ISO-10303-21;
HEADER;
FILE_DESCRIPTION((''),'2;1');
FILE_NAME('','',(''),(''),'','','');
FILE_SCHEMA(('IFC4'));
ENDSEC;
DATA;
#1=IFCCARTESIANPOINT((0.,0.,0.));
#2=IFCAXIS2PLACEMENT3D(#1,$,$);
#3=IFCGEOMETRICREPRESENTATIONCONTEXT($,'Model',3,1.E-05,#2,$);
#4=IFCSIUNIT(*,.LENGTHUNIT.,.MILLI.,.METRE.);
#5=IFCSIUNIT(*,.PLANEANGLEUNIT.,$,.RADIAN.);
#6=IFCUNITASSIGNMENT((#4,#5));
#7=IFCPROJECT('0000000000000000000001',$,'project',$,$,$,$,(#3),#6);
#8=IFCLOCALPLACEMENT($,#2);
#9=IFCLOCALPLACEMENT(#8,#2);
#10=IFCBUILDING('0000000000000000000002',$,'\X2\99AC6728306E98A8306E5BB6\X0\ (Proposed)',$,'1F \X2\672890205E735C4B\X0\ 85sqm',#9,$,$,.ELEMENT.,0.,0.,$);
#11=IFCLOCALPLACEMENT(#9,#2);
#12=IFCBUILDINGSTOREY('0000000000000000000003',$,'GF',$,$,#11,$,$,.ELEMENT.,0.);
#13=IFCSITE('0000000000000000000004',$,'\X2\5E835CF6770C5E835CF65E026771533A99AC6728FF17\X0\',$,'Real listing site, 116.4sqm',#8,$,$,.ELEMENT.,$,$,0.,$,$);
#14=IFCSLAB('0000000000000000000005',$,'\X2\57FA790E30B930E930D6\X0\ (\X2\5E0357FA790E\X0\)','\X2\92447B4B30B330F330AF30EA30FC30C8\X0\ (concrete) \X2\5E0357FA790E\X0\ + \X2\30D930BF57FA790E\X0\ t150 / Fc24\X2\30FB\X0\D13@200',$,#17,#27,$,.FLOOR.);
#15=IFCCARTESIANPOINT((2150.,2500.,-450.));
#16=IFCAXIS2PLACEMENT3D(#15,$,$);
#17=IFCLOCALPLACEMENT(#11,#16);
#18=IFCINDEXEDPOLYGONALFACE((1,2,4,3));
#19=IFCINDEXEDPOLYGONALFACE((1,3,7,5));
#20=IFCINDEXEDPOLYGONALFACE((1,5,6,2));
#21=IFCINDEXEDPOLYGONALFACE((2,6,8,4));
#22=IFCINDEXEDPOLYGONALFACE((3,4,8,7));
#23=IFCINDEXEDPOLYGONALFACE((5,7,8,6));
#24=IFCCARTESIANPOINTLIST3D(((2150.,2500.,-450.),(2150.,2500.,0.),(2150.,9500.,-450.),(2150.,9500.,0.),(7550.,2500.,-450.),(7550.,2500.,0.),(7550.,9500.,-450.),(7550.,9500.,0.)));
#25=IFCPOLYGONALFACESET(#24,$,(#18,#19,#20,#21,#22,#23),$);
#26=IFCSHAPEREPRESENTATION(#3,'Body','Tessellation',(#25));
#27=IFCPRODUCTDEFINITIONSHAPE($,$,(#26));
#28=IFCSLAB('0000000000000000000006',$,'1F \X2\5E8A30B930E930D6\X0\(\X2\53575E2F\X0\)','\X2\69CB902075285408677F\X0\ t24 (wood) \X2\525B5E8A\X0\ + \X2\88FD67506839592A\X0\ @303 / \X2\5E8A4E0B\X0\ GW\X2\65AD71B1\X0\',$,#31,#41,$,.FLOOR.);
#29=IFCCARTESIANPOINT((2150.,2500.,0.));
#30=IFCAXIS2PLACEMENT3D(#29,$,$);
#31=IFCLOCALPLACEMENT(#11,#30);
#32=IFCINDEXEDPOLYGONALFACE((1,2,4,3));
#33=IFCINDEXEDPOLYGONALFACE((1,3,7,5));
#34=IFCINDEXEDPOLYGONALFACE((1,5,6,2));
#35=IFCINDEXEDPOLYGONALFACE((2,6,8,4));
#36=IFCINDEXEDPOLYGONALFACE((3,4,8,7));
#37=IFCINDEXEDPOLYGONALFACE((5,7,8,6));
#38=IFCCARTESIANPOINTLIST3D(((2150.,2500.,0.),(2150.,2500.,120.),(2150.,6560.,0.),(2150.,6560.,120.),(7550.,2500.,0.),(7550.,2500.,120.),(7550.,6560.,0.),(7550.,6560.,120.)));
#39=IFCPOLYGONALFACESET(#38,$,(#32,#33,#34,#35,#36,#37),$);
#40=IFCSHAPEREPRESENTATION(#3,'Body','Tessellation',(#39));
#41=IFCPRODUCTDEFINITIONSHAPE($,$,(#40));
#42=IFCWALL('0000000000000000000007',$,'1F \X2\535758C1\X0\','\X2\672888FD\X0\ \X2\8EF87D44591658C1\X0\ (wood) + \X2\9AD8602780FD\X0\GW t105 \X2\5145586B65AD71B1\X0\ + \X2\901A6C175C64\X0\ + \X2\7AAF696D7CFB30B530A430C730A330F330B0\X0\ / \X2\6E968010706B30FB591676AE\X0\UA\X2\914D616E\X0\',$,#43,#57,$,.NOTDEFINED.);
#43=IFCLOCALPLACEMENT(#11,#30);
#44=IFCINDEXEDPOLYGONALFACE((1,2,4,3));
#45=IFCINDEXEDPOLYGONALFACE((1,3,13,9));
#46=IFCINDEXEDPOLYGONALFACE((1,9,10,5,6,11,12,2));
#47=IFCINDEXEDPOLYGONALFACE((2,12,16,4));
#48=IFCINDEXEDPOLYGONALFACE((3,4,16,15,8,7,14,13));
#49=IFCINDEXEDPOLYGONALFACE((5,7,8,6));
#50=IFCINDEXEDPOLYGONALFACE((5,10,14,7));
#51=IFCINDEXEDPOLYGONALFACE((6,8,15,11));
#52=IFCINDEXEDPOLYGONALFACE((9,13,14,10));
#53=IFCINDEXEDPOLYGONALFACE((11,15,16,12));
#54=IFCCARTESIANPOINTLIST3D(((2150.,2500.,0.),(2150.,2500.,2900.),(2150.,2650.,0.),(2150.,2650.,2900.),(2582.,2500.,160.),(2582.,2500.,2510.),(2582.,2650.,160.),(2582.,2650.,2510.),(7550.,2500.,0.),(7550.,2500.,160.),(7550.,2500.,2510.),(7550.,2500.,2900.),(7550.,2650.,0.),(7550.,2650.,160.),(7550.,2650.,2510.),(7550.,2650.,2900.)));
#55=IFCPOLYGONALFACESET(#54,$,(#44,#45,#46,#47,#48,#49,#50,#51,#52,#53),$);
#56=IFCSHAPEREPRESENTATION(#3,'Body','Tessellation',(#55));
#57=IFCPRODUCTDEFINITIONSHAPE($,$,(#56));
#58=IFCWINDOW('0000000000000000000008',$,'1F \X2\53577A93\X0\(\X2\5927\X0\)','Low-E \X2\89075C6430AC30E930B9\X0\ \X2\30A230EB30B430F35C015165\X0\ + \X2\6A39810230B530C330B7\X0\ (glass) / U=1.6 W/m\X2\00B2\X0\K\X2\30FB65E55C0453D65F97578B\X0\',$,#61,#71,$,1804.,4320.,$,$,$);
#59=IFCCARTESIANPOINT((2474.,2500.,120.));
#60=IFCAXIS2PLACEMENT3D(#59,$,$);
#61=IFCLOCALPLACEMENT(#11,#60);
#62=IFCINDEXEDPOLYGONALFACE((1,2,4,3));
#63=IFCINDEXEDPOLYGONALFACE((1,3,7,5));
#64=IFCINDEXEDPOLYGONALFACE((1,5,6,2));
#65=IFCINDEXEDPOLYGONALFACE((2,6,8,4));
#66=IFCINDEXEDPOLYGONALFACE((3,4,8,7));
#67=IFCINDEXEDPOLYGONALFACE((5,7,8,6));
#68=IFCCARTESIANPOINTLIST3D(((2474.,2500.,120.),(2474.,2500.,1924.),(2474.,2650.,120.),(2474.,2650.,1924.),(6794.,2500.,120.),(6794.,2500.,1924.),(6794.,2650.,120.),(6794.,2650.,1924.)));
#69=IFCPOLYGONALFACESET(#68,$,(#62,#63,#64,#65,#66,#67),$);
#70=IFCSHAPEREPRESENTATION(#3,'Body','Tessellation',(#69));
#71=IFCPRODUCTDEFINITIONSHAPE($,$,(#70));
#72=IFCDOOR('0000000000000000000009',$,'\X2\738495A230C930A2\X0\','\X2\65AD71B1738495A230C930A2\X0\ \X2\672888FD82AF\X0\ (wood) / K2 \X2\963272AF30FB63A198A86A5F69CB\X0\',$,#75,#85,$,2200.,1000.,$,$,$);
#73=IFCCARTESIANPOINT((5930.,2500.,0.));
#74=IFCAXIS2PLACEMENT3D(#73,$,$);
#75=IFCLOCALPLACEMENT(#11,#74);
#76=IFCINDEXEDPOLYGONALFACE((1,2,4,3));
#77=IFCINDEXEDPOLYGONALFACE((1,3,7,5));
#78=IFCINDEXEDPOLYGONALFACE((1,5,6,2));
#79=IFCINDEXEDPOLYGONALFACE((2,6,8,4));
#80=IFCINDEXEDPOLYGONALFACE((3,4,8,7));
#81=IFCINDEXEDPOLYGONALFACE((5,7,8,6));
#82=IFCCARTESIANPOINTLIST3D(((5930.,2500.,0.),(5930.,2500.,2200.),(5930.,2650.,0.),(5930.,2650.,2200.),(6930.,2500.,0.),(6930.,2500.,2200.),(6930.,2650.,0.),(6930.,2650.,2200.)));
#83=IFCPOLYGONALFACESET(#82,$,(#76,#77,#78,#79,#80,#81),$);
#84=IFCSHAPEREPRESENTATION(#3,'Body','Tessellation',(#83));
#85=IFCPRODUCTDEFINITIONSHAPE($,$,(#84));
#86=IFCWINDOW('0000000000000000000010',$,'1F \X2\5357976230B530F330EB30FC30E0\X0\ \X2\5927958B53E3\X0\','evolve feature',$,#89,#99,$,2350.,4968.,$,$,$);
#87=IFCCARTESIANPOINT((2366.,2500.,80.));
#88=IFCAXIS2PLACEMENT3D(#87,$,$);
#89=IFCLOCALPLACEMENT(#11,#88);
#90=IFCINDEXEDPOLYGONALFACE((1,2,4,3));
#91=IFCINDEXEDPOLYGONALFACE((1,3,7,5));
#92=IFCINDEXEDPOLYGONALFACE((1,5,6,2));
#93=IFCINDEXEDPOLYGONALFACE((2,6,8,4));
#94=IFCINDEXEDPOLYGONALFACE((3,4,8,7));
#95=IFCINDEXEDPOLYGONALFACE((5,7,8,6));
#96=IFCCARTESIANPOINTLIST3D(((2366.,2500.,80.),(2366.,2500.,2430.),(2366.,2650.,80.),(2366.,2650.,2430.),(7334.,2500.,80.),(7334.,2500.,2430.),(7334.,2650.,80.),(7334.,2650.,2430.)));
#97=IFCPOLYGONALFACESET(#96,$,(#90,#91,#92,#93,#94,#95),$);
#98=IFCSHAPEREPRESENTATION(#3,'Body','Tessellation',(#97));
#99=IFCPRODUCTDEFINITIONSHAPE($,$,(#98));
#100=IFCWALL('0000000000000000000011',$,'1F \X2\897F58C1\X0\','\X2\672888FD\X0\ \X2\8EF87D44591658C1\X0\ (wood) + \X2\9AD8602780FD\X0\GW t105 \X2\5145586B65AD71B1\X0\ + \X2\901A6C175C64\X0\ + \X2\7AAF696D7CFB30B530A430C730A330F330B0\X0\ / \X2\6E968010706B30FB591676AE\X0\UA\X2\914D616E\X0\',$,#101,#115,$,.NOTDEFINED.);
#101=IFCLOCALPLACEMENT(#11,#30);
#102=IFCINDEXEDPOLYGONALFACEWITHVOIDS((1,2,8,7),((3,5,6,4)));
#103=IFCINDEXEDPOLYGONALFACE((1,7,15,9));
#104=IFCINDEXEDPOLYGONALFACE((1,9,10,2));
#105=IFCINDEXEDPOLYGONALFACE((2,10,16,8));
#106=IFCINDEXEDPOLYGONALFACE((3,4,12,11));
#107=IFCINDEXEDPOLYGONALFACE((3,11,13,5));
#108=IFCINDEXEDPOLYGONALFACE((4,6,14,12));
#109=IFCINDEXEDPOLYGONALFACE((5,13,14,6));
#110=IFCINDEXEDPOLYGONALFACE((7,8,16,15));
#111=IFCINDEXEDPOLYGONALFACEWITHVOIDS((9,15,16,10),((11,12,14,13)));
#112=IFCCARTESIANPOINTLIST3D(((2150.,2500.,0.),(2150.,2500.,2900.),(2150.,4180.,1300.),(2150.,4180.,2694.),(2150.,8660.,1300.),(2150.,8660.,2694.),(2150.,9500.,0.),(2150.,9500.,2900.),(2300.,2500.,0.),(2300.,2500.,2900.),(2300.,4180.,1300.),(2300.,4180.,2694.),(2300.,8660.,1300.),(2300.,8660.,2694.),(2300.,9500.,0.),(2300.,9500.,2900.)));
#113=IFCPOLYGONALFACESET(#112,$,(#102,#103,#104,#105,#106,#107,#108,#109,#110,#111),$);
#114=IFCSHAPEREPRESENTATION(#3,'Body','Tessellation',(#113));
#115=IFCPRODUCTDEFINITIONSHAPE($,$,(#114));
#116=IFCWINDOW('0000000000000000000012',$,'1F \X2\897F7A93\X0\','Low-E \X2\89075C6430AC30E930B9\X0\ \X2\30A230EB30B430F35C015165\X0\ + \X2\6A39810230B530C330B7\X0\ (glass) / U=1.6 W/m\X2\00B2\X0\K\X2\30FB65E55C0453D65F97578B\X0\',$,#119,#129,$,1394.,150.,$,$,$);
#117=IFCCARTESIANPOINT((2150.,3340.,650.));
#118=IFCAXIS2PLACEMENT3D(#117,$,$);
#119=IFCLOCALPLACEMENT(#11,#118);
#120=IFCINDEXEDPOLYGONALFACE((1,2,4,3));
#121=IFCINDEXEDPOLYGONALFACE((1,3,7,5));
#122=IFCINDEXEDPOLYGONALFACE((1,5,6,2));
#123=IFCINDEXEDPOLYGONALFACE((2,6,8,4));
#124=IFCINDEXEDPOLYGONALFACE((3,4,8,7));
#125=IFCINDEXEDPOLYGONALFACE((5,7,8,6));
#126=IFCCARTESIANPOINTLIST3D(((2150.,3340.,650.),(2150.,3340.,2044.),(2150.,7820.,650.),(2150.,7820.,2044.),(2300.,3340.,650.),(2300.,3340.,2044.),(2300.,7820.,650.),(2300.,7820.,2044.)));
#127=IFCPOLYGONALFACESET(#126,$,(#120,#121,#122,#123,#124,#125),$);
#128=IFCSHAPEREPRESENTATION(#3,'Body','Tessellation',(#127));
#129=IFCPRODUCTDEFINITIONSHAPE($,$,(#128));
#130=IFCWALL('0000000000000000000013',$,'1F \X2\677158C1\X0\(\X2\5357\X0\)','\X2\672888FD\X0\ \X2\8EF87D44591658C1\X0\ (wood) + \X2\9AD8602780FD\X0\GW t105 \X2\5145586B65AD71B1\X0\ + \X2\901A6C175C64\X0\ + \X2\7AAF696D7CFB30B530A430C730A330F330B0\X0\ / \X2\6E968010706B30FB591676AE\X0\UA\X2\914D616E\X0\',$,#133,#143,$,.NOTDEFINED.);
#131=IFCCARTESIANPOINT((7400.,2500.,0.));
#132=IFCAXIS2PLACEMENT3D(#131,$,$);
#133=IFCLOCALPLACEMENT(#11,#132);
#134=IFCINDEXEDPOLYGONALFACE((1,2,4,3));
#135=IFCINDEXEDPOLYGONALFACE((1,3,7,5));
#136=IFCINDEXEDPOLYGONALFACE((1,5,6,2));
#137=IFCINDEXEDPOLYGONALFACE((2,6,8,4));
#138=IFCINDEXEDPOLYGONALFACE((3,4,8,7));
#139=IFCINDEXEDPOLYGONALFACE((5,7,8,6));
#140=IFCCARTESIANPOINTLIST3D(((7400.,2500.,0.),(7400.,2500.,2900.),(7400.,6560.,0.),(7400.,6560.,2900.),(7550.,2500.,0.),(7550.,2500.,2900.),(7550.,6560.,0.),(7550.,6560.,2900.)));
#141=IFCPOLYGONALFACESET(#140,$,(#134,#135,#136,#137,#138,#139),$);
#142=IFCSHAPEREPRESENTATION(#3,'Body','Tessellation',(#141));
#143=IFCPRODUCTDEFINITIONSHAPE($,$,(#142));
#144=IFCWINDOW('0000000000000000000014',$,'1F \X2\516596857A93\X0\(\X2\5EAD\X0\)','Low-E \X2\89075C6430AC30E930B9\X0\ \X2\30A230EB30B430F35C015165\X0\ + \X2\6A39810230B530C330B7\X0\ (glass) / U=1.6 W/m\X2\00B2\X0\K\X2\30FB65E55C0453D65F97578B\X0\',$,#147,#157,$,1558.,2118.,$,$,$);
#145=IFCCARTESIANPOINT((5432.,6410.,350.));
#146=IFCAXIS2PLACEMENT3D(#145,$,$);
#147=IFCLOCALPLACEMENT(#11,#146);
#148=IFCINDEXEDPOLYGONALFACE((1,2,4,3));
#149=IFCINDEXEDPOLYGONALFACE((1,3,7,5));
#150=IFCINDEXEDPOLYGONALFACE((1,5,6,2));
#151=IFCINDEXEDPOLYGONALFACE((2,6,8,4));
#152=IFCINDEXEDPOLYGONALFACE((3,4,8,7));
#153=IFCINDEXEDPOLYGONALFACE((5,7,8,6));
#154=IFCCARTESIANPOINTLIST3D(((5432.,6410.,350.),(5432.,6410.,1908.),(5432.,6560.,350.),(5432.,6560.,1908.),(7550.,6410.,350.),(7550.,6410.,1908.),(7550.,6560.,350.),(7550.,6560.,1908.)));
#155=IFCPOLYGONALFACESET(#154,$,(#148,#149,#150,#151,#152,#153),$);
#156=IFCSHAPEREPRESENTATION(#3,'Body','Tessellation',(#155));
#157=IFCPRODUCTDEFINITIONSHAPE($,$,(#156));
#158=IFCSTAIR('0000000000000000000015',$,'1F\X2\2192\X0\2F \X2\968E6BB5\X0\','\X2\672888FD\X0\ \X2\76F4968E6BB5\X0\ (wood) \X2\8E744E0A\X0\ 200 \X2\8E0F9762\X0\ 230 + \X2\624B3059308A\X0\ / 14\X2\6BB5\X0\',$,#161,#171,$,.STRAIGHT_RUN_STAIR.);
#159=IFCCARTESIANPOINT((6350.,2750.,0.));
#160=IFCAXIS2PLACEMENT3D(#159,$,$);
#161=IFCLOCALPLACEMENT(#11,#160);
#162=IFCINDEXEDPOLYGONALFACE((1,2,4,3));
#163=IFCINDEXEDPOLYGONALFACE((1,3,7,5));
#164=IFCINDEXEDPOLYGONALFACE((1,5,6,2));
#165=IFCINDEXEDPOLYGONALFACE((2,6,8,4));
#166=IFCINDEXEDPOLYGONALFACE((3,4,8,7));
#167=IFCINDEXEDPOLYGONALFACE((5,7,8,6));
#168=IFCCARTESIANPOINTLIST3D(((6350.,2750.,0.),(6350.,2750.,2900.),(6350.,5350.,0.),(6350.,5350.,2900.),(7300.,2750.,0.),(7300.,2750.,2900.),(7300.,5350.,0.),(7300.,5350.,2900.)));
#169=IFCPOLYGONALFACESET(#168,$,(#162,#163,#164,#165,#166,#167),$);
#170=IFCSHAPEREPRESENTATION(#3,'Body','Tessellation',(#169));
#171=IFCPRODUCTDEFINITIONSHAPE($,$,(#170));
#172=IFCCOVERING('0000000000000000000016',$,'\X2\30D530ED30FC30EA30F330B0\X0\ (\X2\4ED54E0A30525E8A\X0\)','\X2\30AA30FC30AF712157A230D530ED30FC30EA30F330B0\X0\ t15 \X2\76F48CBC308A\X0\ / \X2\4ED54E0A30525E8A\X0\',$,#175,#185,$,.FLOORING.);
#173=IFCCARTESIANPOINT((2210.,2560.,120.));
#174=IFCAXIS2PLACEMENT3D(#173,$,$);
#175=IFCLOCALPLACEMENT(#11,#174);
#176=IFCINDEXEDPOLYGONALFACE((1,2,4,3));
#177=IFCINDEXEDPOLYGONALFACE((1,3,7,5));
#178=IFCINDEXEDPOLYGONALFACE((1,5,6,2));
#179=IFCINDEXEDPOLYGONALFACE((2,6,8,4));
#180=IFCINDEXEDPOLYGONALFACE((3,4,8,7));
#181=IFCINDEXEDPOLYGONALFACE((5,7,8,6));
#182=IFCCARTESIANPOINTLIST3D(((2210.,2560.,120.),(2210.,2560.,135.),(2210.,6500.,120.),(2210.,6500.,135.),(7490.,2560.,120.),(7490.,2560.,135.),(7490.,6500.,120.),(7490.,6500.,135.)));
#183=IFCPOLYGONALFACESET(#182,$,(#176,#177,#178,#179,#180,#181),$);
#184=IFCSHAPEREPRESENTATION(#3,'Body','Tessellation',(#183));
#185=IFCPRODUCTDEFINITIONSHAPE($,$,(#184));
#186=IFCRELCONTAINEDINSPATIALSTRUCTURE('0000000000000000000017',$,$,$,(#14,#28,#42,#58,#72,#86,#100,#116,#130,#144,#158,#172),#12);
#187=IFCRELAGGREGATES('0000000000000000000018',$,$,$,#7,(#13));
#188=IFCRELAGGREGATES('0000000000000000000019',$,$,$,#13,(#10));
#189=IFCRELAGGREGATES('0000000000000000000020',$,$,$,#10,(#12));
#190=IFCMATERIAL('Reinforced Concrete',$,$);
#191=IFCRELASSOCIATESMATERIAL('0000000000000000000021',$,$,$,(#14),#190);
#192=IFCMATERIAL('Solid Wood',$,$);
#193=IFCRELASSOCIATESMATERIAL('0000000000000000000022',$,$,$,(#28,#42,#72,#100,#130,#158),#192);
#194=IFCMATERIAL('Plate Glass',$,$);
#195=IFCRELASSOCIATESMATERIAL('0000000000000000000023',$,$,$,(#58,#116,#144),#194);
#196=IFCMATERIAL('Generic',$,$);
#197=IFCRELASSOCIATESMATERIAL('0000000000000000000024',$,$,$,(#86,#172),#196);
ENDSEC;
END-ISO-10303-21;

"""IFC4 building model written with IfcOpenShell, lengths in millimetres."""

from ifc_helpers import new_model, si_unit, frame, frame_2d, origin, place, context, project, spatial, rectangle, extrude, material, element, fill, save


model = new_model("IFC4")

# Units and contexts
model_context = context("Model", 3, precision=1e-05, world=origin())
ifc_project = project(units=[si_unit("LENGTHUNIT", "METRE", prefix="MILLI"), si_unit("PLANEANGLEUNIT", "RADIAN")], contexts=[model_context])

# Site, building, storey
site_placement = place(None, origin())
site = spatial("IfcSite", under=ifc_project, at=site_placement, Name="広島県広島市東区馬木７", ObjectType="Real listing site, 116.4sqm", CompositionType="ELEMENT", RefElevation=0.0)
building_placement = place(site_placement, origin())
building = spatial("IfcBuilding", under=site, at=building_placement, Name="馬木の風の家 (Proposed)", ObjectType="1F 木造平屋 85sqm", CompositionType="ELEMENT", ElevationOfRefHeight=0.0, ElevationOfTerrain=0.0)
storey_placement = place(building_placement, origin())
storey = spatial("IfcBuildingStorey", under=building, at=storey_placement, Name="GF", CompositionType="ELEMENT", Elevation=0.0)

# Slabs
ifc_material_1 = material(Name="Reinforced Concrete")
slab_1_placement = place(storey_placement, frame((2150.0, 2500.0, -450.0)))
element("IfcSlab", 1, at=slab_1_placement, inside=storey, material=ifc_material_1, Name="基礎スラブ (布基礎)", Description="鉄筋コンクリート (concrete) 布基礎 + ベタ基礎 t150 / Fc24・D13@200", PredefinedType="FLOOR", context=model_context, shape_type="SweptSolid", body=[
    extrude(rectangle(XDim=5400.0, YDim=7000.0, at=frame_2d((2700.0, 3500.0))), frame((2150.0, 2500.0, -450.0)), (0.0, 0.0, 1.0), 450.0),
])
ifc_material_2 = material(Name="Solid Wood")
slab_2_placement = place(storey_placement, frame((2150.0, 2500.0, 0.0)))
element("IfcSlab", 2, at=slab_2_placement, inside=storey, material=ifc_material_2, Name="1F 床スラブ(南帯)", Description="構造用合板 t24 (wood) 剛床 + 製材根太 @303 / 床下 GW断熱", PredefinedType="FLOOR", context=model_context, shape_type="SweptSolid", body=[
    extrude(rectangle(XDim=5400.0, YDim=4060.0, at=frame_2d((2700.0, 2030.0))), frame((2150.0, 2500.0, 0.0)), (0.0, 0.0, 1.0), 120.0),
])

# Wall, openings, windows, door
wall_1_placement = place(storey_placement, frame((2150.0, 2500.0, 0.0)))
wall_1 = element("IfcWall", 3, at=wall_1_placement, inside=storey, material=ifc_material_2, Name="1F 南壁", Description="木製 軸組外壁 (wood) + 高性能GW t105 充填断熱 + 通気層 + 窯業系サイディング / 準耐火・外皮UA配慮", PredefinedType="NOTDEFINED", context=model_context, shape_type="SweptSolid", body=[
    extrude(rectangle(XDim=5400.0, YDim=150.0, at=frame_2d((2700.0, 75.0))), frame((2150.0, 2500.0, 0.0)), (0.0, 0.0, 1.0), 2900.0),
])
opening_1_placement = place(storey_placement, frame((2474.0, 2500.0, 120.0)))
opening_1 = element("IfcOpeningElement", 4, at=opening_1_placement, cuts=wall_1, PredefinedType="NOTDEFINED", context=model_context, shape_type="SweptSolid", body=[
    extrude(rectangle(XDim=4320.0, YDim=150.0, at=frame_2d((2160.0, 75.0))), frame((2474.0, 2500.0, 120.0)), (0.0, 0.0, 1.0), 1804.0),
])
opening_2_placement = place(storey_placement, frame((5930.0, 2500.0, 0.0)))
opening_2 = element("IfcOpeningElement", 5, at=opening_2_placement, cuts=wall_1, PredefinedType="NOTDEFINED", context=model_context, shape_type="SweptSolid", body=[
    extrude(rectangle(XDim=1000.0, YDim=150.0, at=frame_2d((500.0, 75.0))), frame((5930.0, 2500.0, 0.0)), (0.0, 0.0, 1.0), 2200.0),
])
opening_3_placement = place(storey_placement, frame((2366.0, 2500.0, 80.0)))
opening_3 = element("IfcOpeningElement", 6, at=opening_3_placement, cuts=wall_1, PredefinedType="NOTDEFINED", context=model_context, shape_type="SweptSolid", body=[
    extrude(rectangle(XDim=4968.0, YDim=150.0, at=frame_2d((2484.0, 75.0))), frame((2366.0, 2500.0, 80.0)), (0.0, 0.0, 1.0), 2350.0),
])
ifc_material_3 = material(Name="Plate Glass")
window_1_placement = place(storey_placement, frame((2474.0, 2500.0, 120.0)))
window_1 = element("IfcWindow", 7, at=window_1_placement, inside=storey, material=ifc_material_3, Name="1F 南窓(大)", Description="Low-E 複層ガラス アルゴン封入 + 樹脂サッシ (glass) / U=1.6 W/m²K・日射取得型", OverallHeight=1804.0, OverallWidth=4320.0, context=model_context, shape_type="SweptSolid", body=[
    extrude(rectangle(XDim=4320.0, YDim=150.0, at=frame_2d((2160.0, 75.0))), frame((2474.0, 2500.0, 120.0)), (0.0, 0.0, 1.0), 1804.0),
])
fill(opening_1, window_1)
door_1_placement = place(storey_placement, frame((5930.0, 2500.0, 0.0)))
door_1 = element("IfcDoor", 8, at=door_1_placement, inside=storey, material=ifc_material_2, Name="玄関ドア", Description="断熱玄関ドア 木製芯 (wood) / K2 防犯・採風機構", OverallHeight=2200.0, OverallWidth=1000.0, context=model_context, shape_type="SweptSolid", body=[
    extrude(rectangle(XDim=1000.0, YDim=150.0, at=frame_2d((500.0, 75.0))), frame((5930.0, 2500.0, 0.0)), (0.0, 0.0, 1.0), 2200.0),
])
fill(opening_2, door_1)
ifc_material_4 = material(Name="Generic")
window_2_placement = place(storey_placement, frame((2366.0, 2500.0, 80.0)))
window_2 = element("IfcWindow", 9, at=window_2_placement, inside=storey, material=ifc_material_4, Name="1F 南面サンルーム 大開口", Description="evolve feature", OverallHeight=2350.0, OverallWidth=4968.0, context=model_context, shape_type="SweptSolid", body=[
    extrude(rectangle(XDim=4968.0, YDim=150.0, at=frame_2d((2484.0, 75.0))), frame((2366.0, 2500.0, 80.0)), (0.0, 0.0, 1.0), 2350.0),
])
fill(opening_3, window_2)

# Walls, openings, windows
wall_2_placement = place(storey_placement, frame((2150.0, 2500.0, 0.0)))
wall_2 = element("IfcWall", 10, at=wall_2_placement, inside=storey, material=ifc_material_2, Name="1F 西壁", Description="木製 軸組外壁 (wood) + 高性能GW t105 充填断熱 + 通気層 + 窯業系サイディング / 準耐火・外皮UA配慮", PredefinedType="NOTDEFINED", context=model_context, shape_type="SweptSolid", body=[
    extrude(rectangle(XDim=150.0, YDim=7000.0, at=frame_2d((75.0, 3500.0))), frame((2150.0, 2500.0, 0.0)), (0.0, 0.0, 1.0), 2900.0),
])
opening_4_placement = place(storey_placement, frame((2150.0, 3340.0, 650.0)))
opening_4 = element("IfcOpeningElement", 11, at=opening_4_placement, cuts=wall_2, PredefinedType="NOTDEFINED", context=model_context, shape_type="SweptSolid", body=[
    extrude(rectangle(XDim=150.0, YDim=4480.0, at=frame_2d((75.0, 2240.0))), frame((2150.0, 3340.0, 650.0)), (0.0, 0.0, 1.0), 1394.0),
])
window_3_placement = place(storey_placement, frame((2150.0, 3340.0, 650.0)))
window_3 = element("IfcWindow", 12, at=window_3_placement, inside=storey, material=ifc_material_3, Name="1F 西窓", Description="Low-E 複層ガラス アルゴン封入 + 樹脂サッシ (glass) / U=1.6 W/m²K・日射取得型", OverallHeight=1394.0, OverallWidth=150.0, context=model_context, shape_type="SweptSolid", body=[
    extrude(rectangle(XDim=150.0, YDim=4480.0, at=frame_2d((75.0, 2240.0))), frame((2150.0, 3340.0, 650.0)), (0.0, 0.0, 1.0), 1394.0),
])
fill(opening_4, window_3)
wall_3_placement = place(storey_placement, frame((7400.0, 2500.0, 0.0)))
wall_3 = element("IfcWall", 13, at=wall_3_placement, inside=storey, material=ifc_material_2, Name="1F 東壁(南)", Description="木製 軸組外壁 (wood) + 高性能GW t105 充填断熱 + 通気層 + 窯業系サイディング / 準耐火・外皮UA配慮", PredefinedType="NOTDEFINED", context=model_context, shape_type="SweptSolid", body=[
    extrude(rectangle(XDim=150.0, YDim=4060.0, at=frame_2d((75.0, 2030.0))), frame((7400.0, 2500.0, 0.0)), (0.0, 0.0, 1.0), 2900.0),
])
opening_5_placement = place(storey_placement, frame((5432.0, 6410.0, 350.0)))
opening_5 = element("IfcOpeningElement", 14, at=opening_5_placement, cuts=wall_3, PredefinedType="NOTDEFINED", context=model_context, shape_type="SweptSolid", body=[
    extrude(rectangle(XDim=2118.0, YDim=150.0, at=frame_2d((1059.0, 75.0))), frame((5432.0, 6410.0, 350.0)), (0.0, 0.0, 1.0), 1558.0),
])
window_4_placement = place(storey_placement, frame((5432.0, 6410.0, 350.0)))
window_4 = element("IfcWindow", 15, at=window_4_placement, inside=storey, material=ifc_material_3, Name="1F 入隅窓(庭)", Description="Low-E 複層ガラス アルゴン封入 + 樹脂サッシ (glass) / U=1.6 W/m²K・日射取得型", OverallHeight=1558.0, OverallWidth=2118.0, context=model_context, shape_type="SweptSolid", body=[
    extrude(rectangle(XDim=2118.0, YDim=150.0, at=frame_2d((1059.0, 75.0))), frame((5432.0, 6410.0, 350.0)), (0.0, 0.0, 1.0), 1558.0),
])
fill(opening_5, window_4)

# Stair
stair_placement = place(storey_placement, frame((6350.0, 2750.0, 0.0)))
element("IfcStair", 16, at=stair_placement, inside=storey, material=ifc_material_2, Name="1F→2F 階段", Description="木製 直階段 (wood) 蹴上 200 踏面 230 + 手すり / 14段", PredefinedType="STRAIGHT_RUN_STAIR", context=model_context, shape_type="SweptSolid", body=[
    extrude(rectangle(XDim=950.0, YDim=2600.0, at=frame_2d((475.0, 1300.0))), frame((6350.0, 2750.0, 0.0)), (0.0, 0.0, 1.0), 2900.0),
])

# Covering
covering_placement = place(storey_placement, frame((2210.0, 2560.0, 120.0)))
element("IfcCovering", 17, at=covering_placement, inside=storey, material=ifc_material_4, Name="フローリング (仕上げ床)", Description="オーク無垢フローリング t15 直貼り / 仕上げ床", PredefinedType="FLOORING", context=model_context, shape_type="SweptSolid", body=[
    extrude(rectangle(XDim=5280.0, YDim=3940.0, at=frame_2d((2640.0, 1970.0))), frame((2210.0, 2560.0, 120.0)), (0.0, 0.0, 1.0), 15.0),
])

save(model, "model.ifc")
